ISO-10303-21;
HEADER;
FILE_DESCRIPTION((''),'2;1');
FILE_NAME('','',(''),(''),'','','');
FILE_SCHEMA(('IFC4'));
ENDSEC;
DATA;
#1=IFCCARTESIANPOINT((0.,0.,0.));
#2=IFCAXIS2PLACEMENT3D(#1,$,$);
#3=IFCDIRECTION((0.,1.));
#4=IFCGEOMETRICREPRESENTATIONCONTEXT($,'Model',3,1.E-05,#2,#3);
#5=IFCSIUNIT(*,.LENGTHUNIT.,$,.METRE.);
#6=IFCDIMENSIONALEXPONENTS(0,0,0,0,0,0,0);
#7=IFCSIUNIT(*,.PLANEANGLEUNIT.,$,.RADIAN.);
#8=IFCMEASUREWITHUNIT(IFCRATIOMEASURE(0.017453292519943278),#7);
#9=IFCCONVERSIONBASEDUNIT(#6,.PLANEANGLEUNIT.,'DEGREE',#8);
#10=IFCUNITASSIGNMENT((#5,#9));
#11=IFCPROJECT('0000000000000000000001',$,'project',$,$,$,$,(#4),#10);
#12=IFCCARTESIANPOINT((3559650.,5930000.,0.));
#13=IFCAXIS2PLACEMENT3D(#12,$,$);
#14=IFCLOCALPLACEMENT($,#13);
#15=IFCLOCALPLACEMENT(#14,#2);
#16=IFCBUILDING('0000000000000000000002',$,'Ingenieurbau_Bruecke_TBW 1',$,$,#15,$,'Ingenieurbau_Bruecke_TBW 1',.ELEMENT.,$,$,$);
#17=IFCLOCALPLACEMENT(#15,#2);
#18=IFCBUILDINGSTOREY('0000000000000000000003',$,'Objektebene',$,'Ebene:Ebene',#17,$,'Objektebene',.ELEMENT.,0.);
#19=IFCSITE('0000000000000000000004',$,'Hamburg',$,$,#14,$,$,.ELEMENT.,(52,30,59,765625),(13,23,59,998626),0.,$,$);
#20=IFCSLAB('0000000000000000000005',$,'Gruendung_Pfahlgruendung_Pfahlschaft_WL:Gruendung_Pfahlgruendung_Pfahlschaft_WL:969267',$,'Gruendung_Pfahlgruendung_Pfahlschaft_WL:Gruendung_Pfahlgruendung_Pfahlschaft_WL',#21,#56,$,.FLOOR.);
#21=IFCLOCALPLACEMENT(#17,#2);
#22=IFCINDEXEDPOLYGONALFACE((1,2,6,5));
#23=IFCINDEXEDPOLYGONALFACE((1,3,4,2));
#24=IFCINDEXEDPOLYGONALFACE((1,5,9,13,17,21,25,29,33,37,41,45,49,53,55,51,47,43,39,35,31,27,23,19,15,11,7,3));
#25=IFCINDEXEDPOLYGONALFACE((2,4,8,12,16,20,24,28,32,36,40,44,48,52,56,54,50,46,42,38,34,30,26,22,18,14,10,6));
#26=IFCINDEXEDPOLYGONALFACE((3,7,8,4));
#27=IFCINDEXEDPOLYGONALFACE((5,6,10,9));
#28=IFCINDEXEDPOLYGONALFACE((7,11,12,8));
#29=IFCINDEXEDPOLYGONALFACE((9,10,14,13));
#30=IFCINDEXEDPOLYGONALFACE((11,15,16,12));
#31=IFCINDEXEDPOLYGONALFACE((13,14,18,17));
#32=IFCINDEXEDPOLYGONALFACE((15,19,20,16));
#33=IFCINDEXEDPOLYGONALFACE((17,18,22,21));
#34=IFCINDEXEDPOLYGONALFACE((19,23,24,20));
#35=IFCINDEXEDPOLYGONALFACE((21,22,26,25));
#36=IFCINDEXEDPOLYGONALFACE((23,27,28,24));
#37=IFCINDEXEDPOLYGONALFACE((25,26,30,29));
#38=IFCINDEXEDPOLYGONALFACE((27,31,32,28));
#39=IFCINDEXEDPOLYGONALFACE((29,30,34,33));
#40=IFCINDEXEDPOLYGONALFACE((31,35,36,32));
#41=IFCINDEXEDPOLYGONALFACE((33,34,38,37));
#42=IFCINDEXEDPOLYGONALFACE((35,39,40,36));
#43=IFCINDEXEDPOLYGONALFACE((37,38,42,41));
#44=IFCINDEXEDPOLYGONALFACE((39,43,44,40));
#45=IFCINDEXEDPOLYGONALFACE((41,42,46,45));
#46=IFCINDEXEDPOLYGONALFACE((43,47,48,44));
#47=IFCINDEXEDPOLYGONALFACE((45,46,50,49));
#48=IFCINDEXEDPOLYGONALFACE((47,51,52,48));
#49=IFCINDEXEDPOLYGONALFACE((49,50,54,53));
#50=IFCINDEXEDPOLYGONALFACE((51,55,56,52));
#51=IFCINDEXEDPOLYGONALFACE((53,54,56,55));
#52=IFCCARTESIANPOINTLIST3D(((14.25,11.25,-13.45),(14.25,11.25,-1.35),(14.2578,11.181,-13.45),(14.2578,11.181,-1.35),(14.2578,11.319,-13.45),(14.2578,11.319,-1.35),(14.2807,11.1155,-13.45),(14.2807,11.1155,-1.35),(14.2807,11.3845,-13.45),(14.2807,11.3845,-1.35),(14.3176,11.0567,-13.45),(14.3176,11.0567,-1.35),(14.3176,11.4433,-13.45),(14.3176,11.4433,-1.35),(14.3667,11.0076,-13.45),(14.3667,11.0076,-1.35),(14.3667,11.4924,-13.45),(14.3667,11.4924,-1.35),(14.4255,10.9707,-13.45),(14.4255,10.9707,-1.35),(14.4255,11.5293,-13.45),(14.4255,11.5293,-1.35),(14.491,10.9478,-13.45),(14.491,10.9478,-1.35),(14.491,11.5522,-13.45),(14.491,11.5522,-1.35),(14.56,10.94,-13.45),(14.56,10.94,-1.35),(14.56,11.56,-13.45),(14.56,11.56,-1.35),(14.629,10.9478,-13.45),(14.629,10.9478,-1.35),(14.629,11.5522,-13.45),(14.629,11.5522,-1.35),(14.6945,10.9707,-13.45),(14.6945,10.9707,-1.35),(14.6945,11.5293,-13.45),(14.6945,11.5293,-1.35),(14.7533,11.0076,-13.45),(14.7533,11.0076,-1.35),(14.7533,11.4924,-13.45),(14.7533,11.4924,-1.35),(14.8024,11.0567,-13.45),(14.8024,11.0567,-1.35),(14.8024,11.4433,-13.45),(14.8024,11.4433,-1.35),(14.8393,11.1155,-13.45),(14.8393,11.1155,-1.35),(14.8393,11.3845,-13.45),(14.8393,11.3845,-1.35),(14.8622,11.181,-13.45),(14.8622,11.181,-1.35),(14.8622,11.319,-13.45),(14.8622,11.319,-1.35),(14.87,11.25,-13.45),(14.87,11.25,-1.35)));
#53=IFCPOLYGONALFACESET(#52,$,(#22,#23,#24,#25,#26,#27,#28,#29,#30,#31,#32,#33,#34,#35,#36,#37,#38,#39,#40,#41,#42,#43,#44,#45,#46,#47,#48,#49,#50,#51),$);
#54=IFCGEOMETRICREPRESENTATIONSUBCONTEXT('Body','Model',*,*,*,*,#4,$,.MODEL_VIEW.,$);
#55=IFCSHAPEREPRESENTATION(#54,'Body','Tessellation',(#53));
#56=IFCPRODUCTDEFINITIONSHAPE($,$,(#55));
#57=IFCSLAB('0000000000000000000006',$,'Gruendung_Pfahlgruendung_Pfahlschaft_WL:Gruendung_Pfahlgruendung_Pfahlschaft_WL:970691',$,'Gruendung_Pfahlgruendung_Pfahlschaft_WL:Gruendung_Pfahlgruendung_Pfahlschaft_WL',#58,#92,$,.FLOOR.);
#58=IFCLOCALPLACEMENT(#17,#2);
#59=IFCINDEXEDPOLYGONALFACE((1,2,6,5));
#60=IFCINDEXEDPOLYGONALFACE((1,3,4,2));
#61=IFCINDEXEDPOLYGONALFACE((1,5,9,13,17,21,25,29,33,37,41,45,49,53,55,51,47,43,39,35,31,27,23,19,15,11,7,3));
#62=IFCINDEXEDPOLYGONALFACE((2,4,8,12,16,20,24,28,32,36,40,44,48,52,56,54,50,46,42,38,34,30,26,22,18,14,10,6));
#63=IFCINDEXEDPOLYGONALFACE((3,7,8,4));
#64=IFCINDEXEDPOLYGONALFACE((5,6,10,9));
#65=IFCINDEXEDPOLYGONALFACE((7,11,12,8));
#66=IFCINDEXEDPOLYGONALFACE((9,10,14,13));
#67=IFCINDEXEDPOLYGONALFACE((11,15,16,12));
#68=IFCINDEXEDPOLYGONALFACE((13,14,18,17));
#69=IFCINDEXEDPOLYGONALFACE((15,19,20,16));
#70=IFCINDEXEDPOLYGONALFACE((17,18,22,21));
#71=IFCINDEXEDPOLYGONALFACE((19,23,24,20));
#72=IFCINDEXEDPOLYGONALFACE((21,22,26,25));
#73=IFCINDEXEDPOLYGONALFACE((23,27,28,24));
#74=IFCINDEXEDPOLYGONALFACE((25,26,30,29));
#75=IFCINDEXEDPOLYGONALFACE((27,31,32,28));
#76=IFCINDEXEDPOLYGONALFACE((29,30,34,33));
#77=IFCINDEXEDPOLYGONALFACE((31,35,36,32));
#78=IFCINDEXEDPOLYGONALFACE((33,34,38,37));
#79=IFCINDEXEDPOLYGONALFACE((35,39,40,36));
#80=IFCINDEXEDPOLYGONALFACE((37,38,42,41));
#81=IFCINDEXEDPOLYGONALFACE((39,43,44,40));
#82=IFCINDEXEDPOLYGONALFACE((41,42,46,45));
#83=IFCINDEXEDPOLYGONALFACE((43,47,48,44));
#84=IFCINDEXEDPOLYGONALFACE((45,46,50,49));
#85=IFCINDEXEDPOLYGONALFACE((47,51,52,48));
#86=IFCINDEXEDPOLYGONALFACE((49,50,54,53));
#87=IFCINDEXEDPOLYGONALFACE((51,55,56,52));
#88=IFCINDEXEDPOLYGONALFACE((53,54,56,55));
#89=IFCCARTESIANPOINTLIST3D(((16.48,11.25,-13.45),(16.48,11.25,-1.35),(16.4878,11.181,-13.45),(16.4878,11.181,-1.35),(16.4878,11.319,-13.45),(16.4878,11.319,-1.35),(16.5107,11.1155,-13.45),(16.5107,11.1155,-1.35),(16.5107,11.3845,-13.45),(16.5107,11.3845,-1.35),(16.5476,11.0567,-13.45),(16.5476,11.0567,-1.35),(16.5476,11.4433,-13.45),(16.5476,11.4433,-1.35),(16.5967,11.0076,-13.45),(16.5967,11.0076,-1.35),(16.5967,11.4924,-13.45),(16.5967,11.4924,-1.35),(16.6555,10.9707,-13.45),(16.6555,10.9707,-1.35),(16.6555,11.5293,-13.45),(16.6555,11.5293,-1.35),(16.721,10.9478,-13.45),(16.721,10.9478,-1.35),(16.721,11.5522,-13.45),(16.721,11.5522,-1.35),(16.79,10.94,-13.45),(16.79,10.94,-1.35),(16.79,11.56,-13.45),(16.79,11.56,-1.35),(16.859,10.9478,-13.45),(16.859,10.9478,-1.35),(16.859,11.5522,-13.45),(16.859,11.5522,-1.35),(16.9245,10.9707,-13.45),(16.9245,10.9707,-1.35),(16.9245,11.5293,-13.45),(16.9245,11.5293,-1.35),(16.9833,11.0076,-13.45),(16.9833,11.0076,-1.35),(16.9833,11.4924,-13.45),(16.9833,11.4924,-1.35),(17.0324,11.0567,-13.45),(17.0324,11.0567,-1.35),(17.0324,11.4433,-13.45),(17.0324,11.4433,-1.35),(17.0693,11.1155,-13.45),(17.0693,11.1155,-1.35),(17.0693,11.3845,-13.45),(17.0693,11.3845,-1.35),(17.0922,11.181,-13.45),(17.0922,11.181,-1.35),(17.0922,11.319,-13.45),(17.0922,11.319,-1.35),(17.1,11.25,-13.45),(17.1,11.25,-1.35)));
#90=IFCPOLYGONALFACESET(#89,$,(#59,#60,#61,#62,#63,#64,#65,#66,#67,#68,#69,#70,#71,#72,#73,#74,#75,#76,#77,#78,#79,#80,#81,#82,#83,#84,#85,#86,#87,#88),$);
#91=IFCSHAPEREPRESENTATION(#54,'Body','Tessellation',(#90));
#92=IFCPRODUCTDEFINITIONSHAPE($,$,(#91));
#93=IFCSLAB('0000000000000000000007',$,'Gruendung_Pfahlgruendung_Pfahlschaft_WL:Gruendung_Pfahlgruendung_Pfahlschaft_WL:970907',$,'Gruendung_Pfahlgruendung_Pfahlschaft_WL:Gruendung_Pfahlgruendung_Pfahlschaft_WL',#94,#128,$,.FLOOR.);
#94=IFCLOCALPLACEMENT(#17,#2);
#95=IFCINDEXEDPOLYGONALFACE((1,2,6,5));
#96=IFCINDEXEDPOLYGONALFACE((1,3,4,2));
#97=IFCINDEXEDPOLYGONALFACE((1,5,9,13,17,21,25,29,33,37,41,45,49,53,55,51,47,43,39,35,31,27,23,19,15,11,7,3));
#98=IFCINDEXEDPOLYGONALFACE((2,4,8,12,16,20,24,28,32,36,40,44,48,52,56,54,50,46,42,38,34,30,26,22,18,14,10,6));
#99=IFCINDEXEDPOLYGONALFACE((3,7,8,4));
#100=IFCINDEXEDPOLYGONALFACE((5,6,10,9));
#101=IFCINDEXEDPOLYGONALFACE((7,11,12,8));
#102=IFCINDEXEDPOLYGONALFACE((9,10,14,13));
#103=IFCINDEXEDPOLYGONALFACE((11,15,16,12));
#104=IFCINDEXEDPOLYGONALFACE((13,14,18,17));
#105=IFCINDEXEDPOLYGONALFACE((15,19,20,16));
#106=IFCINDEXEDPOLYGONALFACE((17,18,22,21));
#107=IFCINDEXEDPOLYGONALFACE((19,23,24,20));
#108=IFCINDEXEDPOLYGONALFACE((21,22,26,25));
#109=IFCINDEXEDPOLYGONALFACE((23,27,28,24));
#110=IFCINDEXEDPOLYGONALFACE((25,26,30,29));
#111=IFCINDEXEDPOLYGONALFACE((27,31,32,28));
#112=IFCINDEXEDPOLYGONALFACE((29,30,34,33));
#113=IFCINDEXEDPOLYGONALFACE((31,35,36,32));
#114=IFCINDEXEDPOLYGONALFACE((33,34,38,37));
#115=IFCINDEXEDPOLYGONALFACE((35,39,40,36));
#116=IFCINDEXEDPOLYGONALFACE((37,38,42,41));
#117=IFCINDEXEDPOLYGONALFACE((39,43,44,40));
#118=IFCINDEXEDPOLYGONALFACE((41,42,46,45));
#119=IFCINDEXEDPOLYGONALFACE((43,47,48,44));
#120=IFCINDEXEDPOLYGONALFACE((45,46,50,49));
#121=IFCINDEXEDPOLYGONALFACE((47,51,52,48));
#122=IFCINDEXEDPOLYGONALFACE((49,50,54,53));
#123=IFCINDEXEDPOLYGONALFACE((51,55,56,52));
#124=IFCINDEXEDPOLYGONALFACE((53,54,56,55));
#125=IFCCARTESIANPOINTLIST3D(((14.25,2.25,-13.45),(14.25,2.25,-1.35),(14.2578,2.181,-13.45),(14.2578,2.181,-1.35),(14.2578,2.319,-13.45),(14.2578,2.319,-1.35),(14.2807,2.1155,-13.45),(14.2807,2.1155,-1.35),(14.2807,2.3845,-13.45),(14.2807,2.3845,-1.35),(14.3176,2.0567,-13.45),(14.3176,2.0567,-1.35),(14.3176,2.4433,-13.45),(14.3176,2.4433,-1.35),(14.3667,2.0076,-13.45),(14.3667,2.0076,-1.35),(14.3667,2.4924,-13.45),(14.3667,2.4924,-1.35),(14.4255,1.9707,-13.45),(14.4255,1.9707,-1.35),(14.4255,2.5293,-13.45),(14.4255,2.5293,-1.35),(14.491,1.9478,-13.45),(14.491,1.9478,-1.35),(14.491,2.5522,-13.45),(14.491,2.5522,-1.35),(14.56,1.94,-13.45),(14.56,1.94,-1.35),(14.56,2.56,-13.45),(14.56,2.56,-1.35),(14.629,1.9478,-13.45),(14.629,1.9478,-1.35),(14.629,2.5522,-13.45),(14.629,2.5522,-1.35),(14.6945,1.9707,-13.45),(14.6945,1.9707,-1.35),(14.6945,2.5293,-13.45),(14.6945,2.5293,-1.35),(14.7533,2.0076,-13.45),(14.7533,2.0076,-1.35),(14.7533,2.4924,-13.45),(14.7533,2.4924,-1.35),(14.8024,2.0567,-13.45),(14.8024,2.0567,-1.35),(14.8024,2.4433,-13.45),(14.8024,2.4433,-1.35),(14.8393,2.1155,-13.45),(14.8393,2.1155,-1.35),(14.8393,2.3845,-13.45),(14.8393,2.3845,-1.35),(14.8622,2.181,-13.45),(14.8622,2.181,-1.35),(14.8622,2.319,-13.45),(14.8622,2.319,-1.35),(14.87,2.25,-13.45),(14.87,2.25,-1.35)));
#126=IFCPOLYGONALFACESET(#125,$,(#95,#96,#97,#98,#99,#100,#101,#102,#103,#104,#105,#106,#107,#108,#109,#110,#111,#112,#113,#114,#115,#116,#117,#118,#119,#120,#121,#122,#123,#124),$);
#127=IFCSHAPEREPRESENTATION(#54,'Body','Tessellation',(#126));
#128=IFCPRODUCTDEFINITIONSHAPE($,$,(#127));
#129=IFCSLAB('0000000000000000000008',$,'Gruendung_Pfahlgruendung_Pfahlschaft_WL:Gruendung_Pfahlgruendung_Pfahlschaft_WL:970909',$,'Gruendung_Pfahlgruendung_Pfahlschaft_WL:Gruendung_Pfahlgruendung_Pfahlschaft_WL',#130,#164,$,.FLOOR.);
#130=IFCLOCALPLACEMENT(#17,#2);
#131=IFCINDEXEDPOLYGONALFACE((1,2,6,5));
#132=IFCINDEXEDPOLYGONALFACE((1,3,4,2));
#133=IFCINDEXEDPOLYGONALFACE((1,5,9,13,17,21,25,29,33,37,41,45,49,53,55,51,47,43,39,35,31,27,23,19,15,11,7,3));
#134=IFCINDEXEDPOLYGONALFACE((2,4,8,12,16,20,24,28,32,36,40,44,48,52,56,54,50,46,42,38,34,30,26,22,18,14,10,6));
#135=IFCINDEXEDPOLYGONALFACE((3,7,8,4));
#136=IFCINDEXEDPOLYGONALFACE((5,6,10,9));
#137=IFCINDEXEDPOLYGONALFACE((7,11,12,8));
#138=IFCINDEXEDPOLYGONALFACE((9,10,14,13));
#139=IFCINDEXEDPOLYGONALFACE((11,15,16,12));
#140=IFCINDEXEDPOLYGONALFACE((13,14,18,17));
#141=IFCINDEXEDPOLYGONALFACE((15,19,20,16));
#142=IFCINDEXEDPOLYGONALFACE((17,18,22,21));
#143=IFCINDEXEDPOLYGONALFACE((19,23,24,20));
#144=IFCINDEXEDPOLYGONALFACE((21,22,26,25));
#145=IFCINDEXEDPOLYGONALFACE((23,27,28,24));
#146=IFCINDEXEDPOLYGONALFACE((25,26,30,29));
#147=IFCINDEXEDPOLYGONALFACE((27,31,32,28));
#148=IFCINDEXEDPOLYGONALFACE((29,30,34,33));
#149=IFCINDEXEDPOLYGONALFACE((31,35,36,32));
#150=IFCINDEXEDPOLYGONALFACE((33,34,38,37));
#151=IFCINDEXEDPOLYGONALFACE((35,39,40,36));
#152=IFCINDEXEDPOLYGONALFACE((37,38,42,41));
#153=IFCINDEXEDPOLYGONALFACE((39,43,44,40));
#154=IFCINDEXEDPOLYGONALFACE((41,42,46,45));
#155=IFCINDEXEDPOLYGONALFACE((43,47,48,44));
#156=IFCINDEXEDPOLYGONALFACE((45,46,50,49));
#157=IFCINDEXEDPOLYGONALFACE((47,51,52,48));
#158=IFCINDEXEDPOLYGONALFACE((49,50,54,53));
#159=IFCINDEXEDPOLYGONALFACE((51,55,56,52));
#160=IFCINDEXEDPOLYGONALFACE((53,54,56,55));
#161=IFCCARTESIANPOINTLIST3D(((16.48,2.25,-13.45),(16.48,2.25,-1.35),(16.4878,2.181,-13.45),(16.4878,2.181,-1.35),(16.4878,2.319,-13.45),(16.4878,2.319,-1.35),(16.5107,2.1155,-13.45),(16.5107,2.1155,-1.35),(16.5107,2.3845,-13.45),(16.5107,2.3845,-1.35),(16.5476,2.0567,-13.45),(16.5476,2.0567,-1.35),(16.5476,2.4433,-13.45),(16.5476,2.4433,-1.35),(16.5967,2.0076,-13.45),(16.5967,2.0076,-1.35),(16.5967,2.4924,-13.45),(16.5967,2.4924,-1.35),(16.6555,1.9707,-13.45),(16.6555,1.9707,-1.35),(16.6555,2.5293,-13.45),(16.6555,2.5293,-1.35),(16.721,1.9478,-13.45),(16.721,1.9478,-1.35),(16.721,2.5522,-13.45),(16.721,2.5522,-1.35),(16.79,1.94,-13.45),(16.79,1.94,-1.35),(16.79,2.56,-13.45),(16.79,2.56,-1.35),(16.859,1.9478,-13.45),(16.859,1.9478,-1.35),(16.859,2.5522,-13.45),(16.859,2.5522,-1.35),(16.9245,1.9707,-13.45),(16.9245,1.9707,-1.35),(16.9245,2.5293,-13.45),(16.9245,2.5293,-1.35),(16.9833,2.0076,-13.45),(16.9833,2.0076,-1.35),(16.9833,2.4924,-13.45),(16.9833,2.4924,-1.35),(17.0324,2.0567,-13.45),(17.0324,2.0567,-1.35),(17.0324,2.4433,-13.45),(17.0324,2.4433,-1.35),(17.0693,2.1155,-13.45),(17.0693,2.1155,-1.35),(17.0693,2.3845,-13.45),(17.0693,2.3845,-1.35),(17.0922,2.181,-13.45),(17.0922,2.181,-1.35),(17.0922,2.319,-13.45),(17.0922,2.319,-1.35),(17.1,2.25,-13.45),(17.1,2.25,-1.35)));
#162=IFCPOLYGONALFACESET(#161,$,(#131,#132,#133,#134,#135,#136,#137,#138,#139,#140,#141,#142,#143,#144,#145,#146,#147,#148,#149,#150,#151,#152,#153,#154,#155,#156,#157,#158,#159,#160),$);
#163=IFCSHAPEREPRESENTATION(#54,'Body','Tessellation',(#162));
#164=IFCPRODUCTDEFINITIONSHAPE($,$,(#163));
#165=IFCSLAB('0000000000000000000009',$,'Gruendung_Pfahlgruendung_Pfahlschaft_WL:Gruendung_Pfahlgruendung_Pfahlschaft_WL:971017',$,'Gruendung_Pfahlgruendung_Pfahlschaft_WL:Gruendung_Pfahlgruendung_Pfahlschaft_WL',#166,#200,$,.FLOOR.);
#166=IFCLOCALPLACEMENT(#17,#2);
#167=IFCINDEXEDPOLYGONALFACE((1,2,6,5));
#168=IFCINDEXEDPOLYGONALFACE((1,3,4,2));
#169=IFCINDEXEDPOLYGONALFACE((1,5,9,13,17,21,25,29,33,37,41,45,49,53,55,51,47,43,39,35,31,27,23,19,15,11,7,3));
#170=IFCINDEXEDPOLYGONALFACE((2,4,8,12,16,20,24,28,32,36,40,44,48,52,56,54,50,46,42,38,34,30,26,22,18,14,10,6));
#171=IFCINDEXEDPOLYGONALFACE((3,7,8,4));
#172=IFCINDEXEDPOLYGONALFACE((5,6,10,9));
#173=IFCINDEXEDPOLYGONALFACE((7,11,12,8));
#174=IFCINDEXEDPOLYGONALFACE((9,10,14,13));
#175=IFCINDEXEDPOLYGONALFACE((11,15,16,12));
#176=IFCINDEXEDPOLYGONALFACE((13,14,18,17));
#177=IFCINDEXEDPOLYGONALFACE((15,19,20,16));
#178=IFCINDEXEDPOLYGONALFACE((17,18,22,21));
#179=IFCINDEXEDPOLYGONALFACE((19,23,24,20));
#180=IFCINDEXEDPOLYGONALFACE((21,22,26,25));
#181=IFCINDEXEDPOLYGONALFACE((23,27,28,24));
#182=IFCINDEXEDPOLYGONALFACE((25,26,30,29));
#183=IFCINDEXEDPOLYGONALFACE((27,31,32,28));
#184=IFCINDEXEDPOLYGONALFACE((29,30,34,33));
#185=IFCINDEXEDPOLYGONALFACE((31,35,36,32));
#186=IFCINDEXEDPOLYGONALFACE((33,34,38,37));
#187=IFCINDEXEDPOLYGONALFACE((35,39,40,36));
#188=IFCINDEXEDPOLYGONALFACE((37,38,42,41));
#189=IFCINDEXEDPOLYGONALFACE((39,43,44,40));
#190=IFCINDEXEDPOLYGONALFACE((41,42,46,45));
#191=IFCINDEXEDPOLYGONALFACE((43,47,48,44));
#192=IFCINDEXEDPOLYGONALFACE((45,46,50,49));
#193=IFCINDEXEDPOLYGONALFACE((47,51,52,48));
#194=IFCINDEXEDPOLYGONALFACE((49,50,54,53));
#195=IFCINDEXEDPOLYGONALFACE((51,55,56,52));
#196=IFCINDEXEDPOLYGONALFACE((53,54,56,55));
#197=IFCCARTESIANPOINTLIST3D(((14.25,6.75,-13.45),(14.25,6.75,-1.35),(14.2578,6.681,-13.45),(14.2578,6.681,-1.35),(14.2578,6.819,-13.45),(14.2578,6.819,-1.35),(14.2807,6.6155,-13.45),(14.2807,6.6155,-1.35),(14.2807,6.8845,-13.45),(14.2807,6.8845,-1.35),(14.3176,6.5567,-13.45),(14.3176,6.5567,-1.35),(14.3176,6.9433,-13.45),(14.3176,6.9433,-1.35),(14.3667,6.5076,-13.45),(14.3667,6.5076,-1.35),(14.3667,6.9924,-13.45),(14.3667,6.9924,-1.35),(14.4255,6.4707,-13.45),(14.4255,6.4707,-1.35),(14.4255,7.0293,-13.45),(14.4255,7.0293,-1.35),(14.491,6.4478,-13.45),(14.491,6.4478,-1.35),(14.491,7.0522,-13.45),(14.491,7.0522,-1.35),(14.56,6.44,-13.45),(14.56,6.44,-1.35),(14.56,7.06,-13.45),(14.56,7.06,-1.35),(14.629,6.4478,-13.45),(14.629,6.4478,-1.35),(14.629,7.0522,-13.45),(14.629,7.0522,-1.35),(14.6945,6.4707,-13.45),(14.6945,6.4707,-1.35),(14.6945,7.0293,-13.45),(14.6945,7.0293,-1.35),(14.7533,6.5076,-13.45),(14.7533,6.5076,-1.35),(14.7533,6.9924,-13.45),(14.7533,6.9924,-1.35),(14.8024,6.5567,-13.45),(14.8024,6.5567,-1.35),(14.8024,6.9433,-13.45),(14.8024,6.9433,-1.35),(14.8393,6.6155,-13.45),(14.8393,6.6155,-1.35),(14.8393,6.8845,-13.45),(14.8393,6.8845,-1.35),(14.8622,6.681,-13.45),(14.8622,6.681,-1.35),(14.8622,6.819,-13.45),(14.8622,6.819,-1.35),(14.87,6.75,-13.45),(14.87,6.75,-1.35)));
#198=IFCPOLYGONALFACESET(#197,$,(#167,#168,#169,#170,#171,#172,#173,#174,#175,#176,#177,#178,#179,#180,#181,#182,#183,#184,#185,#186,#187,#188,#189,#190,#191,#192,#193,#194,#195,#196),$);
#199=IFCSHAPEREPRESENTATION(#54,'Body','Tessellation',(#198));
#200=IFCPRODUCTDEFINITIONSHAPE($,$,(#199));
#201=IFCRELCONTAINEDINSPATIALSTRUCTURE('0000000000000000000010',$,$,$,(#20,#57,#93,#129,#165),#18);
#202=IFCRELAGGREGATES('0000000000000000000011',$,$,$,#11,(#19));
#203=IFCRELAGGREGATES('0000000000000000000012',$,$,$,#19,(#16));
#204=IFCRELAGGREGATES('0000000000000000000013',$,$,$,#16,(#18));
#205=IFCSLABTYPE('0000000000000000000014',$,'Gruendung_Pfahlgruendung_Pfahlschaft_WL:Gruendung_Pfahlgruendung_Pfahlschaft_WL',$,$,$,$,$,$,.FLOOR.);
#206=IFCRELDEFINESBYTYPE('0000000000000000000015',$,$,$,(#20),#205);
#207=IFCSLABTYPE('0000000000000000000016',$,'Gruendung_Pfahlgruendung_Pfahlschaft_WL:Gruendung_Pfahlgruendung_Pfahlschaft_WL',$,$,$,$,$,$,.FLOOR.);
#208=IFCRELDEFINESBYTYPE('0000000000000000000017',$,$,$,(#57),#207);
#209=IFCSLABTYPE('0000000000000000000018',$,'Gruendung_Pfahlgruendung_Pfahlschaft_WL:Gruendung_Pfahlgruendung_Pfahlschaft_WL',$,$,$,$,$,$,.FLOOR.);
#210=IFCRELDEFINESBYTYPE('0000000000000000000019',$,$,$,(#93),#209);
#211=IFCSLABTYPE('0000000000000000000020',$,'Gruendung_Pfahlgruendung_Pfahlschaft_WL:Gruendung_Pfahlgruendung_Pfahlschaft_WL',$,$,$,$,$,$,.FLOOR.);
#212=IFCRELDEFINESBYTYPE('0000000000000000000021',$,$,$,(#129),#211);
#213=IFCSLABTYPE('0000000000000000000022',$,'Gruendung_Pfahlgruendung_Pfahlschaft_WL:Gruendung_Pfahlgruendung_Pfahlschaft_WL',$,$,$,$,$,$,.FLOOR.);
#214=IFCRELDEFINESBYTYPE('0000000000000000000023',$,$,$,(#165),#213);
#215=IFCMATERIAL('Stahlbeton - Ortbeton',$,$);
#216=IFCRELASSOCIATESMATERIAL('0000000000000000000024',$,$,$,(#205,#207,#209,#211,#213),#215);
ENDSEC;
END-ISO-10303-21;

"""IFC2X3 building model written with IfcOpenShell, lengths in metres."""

from ifc_helpers import new_model, entity, si_unit, converted_unit, direction, frame, frame_2d, origin, origin_2d_with_axis, place, context, subcontext, project, spatial, circle, extrude, material, type_object, element, save


model = new_model("IFC2X3")

# Units and contexts
model_context = context("Model", 3, precision=1e-05, world=origin(), true_north=direction((0.0, 1.0)))
body_context = subcontext(model_context, "Body", "Model", "MODEL_VIEW")
ifc_project = project(units=[si_unit("LENGTHUNIT", "METRE"), converted_unit("PLANEANGLEUNIT", "DEGREE", entity("IfcRatioMeasure", 0.017453292519943278), si_unit("PLANEANGLEUNIT", "RADIAN"), dimensions=[0, 0, 0, 0, 0, 0, 0])], contexts=[model_context])

# Site, building, storey
site_placement = place(None, frame((3559650.0, 5930000.0, 0.0)))
site = spatial("IfcSite", under=ifc_project, at=site_placement, Name="Hamburg", CompositionType="ELEMENT", RefLatitude=(52, 30, 59, 765625), RefLongitude=(13, 23, 59, 998626), RefElevation=0.0)
building_placement = place(site_placement, origin())
building = spatial("IfcBuilding", under=site, at=building_placement, Name="Ingenieurbau_Bruecke_TBW 1", LongName="Ingenieurbau_Bruecke_TBW 1", CompositionType="ELEMENT")
storey_placement = place(building_placement, origin())
storey = spatial("IfcBuildingStorey", under=building, at=storey_placement, Name="Objektebene", ObjectType="Ebene:Ebene", LongName="Objektebene", CompositionType="ELEMENT", Elevation=0.0)

# Slabs
ifc_material_1 = material(Name="Stahlbeton - Ortbeton")
slab_type_1 = type_object("IfcSlabType", Name="Gruendung_Pfahlgruendung_Pfahlschaft_WL:Gruendung_Pfahlgruendung_Pfahlschaft_WL", PredefinedType="FLOOR", material=ifc_material_1)
slab_1_placement = place(storey_placement, origin())
element("IfcSlab", 1, at=slab_1_placement, inside=storey, type_object=slab_type_1, Name="Gruendung_Pfahlgruendung_Pfahlschaft_WL:Gruendung_Pfahlgruendung_Pfahlschaft_WL:969267", ObjectType="Gruendung_Pfahlgruendung_Pfahlschaft_WL:Gruendung_Pfahlgruendung_Pfahlschaft_WL", PredefinedType="FLOOR", context=body_context, shape_type="SweptSolid", body=[
    extrude(circle(Radius=0.31, at=origin_2d_with_axis()), frame((14.56, 11.25, -13.45)), (0.0, 0.0, 1.0), 12.1),
])
slab_type_2 = type_object("IfcSlabType", Name="Gruendung_Pfahlgruendung_Pfahlschaft_WL:Gruendung_Pfahlgruendung_Pfahlschaft_WL", PredefinedType="FLOOR", material=ifc_material_1)
slab_2_placement = place(storey_placement, origin())
element("IfcSlab", 2, at=slab_2_placement, inside=storey, type_object=slab_type_2, Name="Gruendung_Pfahlgruendung_Pfahlschaft_WL:Gruendung_Pfahlgruendung_Pfahlschaft_WL:970691", ObjectType="Gruendung_Pfahlgruendung_Pfahlschaft_WL:Gruendung_Pfahlgruendung_Pfahlschaft_WL", PredefinedType="FLOOR", context=body_context, shape_type="SweptSolid", body=[
    extrude(circle(Radius=0.31, at=origin_2d_with_axis()), frame((16.79, 11.25, -13.45), z_axis=(0.0, 0.0, 1.0), x_axis=(-1.0, 0.0, 0.0)), (0.0, 0.0, 1.0), 12.1),
])
slab_type_3 = type_object("IfcSlabType", Name="Gruendung_Pfahlgruendung_Pfahlschaft_WL:Gruendung_Pfahlgruendung_Pfahlschaft_WL", PredefinedType="FLOOR", material=ifc_material_1)
slab_3_placement = place(storey_placement, origin())
element("IfcSlab", 3, at=slab_3_placement, inside=storey, type_object=slab_type_3, Name="Gruendung_Pfahlgruendung_Pfahlschaft_WL:Gruendung_Pfahlgruendung_Pfahlschaft_WL:970907", ObjectType="Gruendung_Pfahlgruendung_Pfahlschaft_WL:Gruendung_Pfahlgruendung_Pfahlschaft_WL", PredefinedType="FLOOR", context=body_context, shape_type="SweptSolid", body=[
    extrude(circle(Radius=0.31, at=frame_2d((0.0, 0.0), x_axis=(1.0, 0.0))), frame((14.56, 2.25, -13.45)), (0.0, 0.0, 1.0), 12.1),
])
slab_type_4 = type_object("IfcSlabType", Name="Gruendung_Pfahlgruendung_Pfahlschaft_WL:Gruendung_Pfahlgruendung_Pfahlschaft_WL", PredefinedType="FLOOR", material=ifc_material_1)
slab_4_placement = place(storey_placement, origin())
element("IfcSlab", 4, at=slab_4_placement, inside=storey, type_object=slab_type_4, Name="Gruendung_Pfahlgruendung_Pfahlschaft_WL:Gruendung_Pfahlgruendung_Pfahlschaft_WL:970909", ObjectType="Gruendung_Pfahlgruendung_Pfahlschaft_WL:Gruendung_Pfahlgruendung_Pfahlschaft_WL", PredefinedType="FLOOR", context=body_context, shape_type="SweptSolid", body=[
    extrude(circle(Radius=0.31, at=frame_2d((0.0, 0.0), x_axis=(1.0, 0.0))), frame((16.79, 2.25, -13.45), z_axis=(0.0, 0.0, 1.0), x_axis=(-1.0, 0.0, 0.0)), (0.0, 0.0, 1.0), 12.1),
])
slab_type_5 = type_object("IfcSlabType", Name="Gruendung_Pfahlgruendung_Pfahlschaft_WL:Gruendung_Pfahlgruendung_Pfahlschaft_WL", PredefinedType="FLOOR", material=ifc_material_1)
slab_5_placement = place(storey_placement, origin())
element("IfcSlab", 5, at=slab_5_placement, inside=storey, type_object=slab_type_5, Name="Gruendung_Pfahlgruendung_Pfahlschaft_WL:Gruendung_Pfahlgruendung_Pfahlschaft_WL:971017", ObjectType="Gruendung_Pfahlgruendung_Pfahlschaft_WL:Gruendung_Pfahlgruendung_Pfahlschaft_WL", PredefinedType="FLOOR", context=body_context, shape_type="SweptSolid", body=[
    extrude(circle(Radius=0.31, at=frame_2d((0.0, 0.0), x_axis=(1.0, 0.0))), frame((14.56, 6.75, -13.45)), (0.0, 0.0, 1.0), 12.1),
])

save(model, "model.ifc")
